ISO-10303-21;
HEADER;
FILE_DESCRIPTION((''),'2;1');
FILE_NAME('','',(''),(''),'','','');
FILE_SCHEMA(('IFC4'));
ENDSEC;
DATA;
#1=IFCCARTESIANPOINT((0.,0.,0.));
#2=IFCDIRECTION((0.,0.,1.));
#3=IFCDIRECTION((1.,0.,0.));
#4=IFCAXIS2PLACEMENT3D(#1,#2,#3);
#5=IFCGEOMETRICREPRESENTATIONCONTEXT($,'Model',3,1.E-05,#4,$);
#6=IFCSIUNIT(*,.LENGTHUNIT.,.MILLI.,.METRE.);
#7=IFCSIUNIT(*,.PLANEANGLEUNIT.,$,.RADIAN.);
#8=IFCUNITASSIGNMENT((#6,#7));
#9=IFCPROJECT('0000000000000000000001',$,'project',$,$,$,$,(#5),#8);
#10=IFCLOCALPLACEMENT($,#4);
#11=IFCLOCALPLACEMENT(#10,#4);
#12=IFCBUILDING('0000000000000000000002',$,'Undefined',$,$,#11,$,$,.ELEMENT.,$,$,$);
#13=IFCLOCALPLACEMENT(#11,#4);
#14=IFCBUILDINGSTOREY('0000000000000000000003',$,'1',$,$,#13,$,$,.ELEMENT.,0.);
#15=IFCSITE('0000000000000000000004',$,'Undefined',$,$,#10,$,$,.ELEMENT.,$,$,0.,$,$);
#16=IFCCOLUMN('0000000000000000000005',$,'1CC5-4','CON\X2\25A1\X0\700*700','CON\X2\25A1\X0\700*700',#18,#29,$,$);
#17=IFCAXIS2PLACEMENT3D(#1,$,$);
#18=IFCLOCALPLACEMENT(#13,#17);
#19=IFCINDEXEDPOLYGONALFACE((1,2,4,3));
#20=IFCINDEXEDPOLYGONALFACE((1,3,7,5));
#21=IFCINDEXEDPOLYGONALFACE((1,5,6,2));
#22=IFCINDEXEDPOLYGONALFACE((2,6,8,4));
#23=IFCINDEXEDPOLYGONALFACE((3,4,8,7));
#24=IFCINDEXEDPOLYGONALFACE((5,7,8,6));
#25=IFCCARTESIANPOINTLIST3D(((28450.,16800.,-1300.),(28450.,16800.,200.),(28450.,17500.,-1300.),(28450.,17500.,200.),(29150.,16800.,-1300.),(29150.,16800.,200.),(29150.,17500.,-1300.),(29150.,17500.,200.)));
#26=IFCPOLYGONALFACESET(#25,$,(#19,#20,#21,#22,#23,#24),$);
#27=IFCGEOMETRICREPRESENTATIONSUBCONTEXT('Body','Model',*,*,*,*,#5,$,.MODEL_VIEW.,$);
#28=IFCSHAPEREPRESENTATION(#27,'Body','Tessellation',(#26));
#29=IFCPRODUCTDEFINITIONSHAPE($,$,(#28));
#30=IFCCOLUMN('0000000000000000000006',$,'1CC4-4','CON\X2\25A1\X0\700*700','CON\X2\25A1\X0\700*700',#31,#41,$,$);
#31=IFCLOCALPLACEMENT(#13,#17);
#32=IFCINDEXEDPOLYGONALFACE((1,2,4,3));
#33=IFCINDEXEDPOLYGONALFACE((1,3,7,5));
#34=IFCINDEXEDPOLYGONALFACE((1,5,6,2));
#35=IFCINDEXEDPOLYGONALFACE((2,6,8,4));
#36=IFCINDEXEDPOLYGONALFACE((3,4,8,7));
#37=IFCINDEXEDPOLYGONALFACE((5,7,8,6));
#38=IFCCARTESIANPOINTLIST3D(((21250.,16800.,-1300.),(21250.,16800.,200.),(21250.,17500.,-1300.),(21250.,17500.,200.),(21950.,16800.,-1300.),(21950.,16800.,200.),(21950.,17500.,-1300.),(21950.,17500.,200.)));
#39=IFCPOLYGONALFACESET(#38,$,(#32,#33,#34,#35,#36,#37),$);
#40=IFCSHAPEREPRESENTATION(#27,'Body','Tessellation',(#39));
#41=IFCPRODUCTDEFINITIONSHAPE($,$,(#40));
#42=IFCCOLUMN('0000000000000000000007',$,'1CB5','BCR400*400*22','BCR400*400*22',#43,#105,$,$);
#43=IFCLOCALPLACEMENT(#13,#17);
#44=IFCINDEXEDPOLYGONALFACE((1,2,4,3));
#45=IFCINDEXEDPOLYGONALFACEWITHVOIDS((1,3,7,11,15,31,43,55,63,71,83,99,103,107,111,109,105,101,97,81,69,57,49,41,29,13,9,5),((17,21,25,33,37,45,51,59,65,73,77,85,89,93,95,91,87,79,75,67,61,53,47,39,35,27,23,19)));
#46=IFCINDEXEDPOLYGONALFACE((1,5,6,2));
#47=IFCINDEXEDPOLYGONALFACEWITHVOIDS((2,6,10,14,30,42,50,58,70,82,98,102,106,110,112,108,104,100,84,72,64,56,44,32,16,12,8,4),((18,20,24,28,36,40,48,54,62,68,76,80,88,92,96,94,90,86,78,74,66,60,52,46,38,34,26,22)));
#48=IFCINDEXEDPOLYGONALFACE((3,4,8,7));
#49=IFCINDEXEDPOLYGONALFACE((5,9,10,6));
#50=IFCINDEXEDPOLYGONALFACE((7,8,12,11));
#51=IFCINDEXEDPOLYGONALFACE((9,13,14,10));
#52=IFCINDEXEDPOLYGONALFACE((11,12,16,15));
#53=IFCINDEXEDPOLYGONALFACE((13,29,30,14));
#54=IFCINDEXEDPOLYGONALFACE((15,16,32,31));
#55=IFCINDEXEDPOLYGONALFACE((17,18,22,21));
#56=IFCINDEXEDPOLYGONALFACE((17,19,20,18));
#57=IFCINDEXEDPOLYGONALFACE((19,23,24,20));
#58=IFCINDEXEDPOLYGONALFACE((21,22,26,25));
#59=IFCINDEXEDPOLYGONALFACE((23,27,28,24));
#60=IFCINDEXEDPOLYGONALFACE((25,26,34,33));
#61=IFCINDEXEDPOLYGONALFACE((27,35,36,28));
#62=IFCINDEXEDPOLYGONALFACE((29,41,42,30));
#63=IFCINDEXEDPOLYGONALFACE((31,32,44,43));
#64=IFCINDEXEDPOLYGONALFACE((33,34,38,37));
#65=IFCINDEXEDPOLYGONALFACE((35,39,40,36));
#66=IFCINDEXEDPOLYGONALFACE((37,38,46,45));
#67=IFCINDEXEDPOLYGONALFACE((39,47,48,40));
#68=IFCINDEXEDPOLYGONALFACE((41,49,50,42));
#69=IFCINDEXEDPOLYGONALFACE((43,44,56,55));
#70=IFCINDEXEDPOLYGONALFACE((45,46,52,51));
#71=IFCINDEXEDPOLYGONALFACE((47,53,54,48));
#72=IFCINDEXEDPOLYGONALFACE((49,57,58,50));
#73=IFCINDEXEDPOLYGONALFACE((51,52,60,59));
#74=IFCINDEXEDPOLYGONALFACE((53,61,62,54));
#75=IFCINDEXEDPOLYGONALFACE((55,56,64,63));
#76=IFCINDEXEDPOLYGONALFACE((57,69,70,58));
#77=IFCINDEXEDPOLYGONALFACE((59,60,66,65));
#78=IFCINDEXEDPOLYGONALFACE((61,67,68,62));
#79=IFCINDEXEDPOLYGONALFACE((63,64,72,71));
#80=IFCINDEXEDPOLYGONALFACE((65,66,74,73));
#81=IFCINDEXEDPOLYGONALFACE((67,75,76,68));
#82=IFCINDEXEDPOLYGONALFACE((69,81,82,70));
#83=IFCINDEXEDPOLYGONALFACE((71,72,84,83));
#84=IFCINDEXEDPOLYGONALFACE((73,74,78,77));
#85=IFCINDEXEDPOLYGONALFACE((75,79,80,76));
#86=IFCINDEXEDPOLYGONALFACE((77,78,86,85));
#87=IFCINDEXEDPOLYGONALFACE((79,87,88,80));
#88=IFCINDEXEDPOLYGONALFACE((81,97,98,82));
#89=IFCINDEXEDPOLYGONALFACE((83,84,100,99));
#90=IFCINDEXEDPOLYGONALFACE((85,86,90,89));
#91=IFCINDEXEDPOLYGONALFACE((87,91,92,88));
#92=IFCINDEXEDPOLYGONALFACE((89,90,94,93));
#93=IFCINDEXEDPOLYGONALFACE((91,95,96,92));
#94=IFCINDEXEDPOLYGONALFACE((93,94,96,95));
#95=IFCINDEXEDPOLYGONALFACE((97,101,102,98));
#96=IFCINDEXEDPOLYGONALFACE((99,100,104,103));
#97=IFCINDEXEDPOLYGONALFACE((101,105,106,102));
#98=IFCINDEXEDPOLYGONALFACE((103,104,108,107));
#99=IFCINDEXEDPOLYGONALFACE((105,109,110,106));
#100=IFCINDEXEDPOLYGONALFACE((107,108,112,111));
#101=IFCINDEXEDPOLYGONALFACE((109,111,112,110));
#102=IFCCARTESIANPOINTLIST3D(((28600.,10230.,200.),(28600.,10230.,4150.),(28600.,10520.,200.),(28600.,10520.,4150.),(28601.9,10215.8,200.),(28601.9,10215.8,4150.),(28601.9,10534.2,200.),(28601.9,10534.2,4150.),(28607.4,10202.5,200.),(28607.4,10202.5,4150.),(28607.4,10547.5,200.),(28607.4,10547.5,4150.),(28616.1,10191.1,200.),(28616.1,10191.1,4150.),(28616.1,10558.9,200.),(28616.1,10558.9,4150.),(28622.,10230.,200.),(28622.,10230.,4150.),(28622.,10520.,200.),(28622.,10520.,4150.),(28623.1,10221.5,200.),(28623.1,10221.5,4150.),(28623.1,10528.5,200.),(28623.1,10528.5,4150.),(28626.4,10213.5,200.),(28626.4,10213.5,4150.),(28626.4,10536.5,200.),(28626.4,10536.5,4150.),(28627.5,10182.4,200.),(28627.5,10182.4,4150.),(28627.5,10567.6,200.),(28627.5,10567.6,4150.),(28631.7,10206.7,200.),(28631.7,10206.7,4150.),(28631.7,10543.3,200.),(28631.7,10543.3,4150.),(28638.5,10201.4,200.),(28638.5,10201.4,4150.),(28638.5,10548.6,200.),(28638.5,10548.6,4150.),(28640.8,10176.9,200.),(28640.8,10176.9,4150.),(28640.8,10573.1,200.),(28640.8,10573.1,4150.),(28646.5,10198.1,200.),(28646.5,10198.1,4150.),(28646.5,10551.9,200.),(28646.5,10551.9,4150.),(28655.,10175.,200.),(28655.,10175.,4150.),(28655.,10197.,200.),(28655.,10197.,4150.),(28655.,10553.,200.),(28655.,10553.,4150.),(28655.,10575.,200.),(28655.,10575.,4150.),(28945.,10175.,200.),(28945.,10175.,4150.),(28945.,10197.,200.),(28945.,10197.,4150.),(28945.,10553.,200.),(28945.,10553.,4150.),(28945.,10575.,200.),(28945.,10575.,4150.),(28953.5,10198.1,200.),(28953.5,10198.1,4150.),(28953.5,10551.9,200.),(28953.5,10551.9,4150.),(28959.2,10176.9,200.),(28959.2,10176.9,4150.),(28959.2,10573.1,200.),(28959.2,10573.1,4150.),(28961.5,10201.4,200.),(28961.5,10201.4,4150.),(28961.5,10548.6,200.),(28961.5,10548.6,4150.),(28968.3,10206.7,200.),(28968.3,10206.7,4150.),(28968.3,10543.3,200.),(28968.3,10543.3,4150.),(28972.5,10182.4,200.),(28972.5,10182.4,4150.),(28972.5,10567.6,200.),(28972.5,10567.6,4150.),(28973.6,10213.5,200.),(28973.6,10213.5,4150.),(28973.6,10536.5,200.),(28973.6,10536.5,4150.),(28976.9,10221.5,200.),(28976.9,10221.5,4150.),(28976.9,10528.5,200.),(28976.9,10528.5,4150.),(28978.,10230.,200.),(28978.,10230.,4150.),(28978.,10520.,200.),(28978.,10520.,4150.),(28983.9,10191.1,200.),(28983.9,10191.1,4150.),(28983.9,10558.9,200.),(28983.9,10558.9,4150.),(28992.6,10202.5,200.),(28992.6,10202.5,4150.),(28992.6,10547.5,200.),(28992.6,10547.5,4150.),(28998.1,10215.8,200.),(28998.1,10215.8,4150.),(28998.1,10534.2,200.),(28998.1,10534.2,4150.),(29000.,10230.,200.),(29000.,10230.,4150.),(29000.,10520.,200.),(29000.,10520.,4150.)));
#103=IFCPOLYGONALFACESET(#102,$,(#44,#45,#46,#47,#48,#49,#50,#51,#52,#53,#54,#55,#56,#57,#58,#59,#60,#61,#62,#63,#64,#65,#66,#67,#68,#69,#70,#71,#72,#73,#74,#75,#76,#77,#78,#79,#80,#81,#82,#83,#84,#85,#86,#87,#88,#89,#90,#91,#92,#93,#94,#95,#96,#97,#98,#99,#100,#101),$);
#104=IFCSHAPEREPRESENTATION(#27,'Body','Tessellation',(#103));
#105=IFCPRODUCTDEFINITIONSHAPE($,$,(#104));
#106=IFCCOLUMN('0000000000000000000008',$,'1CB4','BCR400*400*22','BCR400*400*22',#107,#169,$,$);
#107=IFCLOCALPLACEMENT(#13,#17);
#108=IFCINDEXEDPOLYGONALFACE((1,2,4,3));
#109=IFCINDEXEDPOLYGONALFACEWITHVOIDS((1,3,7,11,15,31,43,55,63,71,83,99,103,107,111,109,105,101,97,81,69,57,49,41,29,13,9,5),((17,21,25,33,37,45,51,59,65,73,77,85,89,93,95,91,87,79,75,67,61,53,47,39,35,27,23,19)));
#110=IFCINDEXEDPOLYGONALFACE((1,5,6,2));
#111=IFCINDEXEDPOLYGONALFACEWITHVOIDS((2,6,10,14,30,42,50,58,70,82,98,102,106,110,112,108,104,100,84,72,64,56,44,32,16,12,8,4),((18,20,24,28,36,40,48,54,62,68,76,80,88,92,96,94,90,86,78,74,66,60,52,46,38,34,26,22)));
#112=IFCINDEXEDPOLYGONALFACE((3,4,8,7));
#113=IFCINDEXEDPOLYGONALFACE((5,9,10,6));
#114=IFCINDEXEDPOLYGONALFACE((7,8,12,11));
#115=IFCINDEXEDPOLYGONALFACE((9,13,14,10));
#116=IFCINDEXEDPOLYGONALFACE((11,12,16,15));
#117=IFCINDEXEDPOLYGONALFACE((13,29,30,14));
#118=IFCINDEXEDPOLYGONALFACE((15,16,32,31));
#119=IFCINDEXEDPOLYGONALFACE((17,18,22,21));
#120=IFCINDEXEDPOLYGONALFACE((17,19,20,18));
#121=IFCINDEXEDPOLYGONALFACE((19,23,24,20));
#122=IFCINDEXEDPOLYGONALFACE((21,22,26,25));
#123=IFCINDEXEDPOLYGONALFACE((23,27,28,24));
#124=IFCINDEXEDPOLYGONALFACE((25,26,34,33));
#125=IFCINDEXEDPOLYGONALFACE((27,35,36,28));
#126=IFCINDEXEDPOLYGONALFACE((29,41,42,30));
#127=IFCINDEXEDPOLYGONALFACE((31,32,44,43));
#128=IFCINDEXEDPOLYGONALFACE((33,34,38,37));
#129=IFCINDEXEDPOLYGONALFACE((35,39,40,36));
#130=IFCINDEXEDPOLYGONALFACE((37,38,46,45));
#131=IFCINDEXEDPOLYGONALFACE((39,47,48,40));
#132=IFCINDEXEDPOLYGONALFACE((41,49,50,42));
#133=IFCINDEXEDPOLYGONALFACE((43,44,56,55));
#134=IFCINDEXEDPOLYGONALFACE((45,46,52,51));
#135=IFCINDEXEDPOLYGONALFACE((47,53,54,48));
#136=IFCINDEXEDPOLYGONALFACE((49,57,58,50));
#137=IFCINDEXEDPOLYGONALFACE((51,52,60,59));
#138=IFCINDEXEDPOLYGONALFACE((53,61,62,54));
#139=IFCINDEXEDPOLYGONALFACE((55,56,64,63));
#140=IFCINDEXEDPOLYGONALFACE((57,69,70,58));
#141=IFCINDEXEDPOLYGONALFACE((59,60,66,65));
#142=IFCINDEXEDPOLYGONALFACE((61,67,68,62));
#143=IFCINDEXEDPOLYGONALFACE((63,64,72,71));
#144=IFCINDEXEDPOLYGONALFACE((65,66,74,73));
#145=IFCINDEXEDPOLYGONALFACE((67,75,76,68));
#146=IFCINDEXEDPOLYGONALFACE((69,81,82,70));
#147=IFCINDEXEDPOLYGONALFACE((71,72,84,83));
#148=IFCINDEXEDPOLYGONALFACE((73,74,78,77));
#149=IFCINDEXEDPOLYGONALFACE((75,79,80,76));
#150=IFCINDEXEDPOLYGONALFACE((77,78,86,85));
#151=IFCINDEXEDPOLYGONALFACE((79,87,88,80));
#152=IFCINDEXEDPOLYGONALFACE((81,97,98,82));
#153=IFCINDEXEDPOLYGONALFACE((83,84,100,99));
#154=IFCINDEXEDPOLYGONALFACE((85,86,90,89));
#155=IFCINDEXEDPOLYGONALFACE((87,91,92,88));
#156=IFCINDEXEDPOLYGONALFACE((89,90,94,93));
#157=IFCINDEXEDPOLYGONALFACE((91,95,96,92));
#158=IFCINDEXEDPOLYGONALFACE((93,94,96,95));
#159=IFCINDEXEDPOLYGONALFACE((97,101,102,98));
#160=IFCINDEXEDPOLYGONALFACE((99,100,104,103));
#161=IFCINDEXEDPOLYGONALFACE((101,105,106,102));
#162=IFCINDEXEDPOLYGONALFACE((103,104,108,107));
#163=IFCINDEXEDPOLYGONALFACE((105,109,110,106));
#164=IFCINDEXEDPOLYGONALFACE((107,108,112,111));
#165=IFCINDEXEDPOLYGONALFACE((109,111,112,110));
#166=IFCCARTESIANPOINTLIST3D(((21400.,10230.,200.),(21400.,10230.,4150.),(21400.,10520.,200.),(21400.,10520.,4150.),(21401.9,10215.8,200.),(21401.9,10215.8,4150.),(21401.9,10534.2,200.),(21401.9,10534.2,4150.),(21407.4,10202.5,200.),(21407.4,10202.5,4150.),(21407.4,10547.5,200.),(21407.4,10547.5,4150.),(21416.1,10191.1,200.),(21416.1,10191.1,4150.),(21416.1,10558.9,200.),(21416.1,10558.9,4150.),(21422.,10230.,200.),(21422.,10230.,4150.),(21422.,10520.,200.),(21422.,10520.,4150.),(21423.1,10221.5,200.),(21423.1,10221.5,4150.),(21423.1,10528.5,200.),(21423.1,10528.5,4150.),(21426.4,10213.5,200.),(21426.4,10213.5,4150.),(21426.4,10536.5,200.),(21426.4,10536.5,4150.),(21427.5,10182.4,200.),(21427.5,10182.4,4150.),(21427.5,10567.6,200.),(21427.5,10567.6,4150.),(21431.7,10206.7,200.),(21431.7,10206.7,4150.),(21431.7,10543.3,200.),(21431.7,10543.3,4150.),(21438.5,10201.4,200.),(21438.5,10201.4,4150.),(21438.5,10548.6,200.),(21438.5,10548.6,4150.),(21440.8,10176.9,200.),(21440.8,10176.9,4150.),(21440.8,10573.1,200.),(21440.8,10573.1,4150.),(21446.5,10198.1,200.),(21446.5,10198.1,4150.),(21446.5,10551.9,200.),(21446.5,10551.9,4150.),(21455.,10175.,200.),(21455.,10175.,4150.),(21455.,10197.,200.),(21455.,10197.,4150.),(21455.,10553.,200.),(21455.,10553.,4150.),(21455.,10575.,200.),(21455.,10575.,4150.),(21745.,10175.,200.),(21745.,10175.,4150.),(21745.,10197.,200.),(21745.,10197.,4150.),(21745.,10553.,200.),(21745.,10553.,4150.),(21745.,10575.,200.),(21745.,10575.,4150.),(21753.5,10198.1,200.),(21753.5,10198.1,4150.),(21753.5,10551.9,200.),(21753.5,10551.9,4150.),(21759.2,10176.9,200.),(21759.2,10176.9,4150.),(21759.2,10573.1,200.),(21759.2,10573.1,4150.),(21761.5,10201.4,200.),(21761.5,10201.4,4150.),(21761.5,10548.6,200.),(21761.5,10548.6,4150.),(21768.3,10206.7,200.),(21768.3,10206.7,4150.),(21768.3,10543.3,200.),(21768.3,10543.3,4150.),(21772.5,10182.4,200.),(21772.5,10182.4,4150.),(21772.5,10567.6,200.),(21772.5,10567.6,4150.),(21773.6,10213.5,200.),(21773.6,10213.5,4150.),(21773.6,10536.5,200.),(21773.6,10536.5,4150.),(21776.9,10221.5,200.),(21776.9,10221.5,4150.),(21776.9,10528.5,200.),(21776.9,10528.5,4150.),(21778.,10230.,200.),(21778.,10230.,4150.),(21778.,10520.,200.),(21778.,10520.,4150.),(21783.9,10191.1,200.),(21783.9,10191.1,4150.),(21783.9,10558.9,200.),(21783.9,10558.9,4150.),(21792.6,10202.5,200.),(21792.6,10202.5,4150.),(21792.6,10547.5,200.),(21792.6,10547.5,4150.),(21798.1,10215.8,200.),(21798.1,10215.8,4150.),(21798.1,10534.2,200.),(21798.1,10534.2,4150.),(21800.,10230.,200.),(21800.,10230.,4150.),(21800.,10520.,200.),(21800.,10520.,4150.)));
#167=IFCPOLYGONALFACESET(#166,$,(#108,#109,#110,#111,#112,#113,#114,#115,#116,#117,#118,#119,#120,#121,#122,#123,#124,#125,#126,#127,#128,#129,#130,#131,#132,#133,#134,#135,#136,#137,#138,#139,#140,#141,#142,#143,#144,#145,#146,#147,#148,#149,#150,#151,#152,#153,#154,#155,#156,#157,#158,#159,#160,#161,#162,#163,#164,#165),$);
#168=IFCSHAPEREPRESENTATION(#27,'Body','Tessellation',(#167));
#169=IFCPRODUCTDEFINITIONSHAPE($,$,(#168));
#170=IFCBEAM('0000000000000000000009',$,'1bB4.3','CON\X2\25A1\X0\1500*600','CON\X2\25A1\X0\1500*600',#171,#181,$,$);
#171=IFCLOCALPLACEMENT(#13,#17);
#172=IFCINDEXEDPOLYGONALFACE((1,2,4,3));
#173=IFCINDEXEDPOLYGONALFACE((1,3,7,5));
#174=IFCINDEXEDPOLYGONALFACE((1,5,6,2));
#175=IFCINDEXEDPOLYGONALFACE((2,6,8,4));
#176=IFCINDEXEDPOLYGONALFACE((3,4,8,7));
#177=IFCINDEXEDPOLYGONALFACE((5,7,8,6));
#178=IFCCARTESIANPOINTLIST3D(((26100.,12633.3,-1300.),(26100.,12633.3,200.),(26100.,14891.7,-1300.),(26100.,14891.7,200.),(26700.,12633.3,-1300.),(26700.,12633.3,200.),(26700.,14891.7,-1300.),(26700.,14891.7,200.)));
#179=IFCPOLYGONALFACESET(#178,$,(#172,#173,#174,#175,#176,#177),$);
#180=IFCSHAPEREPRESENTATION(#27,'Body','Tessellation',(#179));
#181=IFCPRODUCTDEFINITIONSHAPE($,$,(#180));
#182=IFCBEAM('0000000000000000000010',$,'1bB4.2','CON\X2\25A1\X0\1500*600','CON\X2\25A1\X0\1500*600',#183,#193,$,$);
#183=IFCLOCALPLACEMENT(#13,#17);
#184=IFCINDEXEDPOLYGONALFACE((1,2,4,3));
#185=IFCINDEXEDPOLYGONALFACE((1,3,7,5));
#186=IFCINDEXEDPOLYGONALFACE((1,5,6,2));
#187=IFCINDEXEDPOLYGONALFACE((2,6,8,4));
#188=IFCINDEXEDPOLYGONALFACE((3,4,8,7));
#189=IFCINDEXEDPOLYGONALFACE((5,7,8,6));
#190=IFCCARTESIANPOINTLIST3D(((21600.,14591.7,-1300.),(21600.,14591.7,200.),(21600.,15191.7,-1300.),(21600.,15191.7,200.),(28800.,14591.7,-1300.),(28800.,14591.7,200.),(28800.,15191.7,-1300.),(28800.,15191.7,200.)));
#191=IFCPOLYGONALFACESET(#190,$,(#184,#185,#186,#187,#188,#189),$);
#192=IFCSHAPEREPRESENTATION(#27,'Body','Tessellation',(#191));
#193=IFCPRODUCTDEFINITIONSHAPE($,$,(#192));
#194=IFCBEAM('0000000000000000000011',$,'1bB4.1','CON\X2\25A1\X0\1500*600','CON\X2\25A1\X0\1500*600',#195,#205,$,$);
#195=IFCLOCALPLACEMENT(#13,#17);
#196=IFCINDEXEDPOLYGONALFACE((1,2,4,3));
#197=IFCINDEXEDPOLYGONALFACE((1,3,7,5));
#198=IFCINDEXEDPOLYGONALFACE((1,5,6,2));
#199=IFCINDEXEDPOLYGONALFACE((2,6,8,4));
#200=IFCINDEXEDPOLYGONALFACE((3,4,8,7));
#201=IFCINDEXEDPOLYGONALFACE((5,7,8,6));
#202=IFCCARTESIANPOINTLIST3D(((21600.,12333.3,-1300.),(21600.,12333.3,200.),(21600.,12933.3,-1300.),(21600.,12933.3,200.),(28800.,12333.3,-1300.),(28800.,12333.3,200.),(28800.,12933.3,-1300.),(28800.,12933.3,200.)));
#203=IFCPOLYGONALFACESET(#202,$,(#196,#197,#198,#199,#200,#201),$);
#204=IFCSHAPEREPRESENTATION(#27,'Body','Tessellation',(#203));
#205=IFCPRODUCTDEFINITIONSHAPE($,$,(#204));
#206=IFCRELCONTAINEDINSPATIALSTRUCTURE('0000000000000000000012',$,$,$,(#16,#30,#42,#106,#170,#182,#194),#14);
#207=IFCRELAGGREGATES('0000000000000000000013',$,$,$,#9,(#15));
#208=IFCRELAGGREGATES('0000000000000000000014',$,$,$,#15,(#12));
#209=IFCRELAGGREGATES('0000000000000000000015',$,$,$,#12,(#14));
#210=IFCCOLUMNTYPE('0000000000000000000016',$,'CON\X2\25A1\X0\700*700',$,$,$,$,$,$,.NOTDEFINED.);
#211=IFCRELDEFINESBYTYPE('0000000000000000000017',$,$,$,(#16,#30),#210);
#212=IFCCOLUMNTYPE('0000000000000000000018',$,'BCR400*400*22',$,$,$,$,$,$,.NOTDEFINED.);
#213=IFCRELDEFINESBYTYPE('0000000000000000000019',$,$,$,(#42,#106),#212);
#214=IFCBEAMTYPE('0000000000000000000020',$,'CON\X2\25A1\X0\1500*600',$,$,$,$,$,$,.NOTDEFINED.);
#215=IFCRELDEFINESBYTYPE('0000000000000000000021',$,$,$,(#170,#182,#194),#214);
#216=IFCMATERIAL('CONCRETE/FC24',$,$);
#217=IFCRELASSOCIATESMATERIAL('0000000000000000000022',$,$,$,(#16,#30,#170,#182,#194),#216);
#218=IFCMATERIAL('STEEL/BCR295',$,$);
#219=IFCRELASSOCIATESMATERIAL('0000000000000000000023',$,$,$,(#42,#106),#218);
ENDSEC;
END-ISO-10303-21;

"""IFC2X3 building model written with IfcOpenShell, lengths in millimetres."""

from ifc_helpers import new_model, si_unit, frame, origin_with_axes, origin_2d_with_axis, place, context, subcontext, project, spatial, rectangle, hollow_rectangle, extrude, material, type_object, element, save


model = new_model("IFC2X3")

# Units and contexts
model_context = context("Model", 3, precision=1e-05, world=origin_with_axes())
body_context = subcontext(model_context, "Body", "Model", "MODEL_VIEW")
ifc_project = project(units=[si_unit("LENGTHUNIT", "METRE", prefix="MILLI"), si_unit("PLANEANGLEUNIT", "RADIAN")], contexts=[model_context])

# Site, building, storey
site_placement = place(None, origin_with_axes())
site = spatial("IfcSite", under=ifc_project, at=site_placement, Name="Undefined", CompositionType="ELEMENT", RefElevation=0.0)
building_placement = place(site_placement, origin_with_axes())
building = spatial("IfcBuilding", under=site, at=building_placement, Name="Undefined", CompositionType="ELEMENT")
storey_placement = place(building_placement, origin_with_axes())
storey = spatial("IfcBuildingStorey", under=building, at=storey_placement, Name="1", CompositionType="ELEMENT", Elevation=0.0)

# Shared definitions
ifc_material_1 = material(Name="CONCRETE/FC24")

# Columns
ifc_material_2 = material(Name="STEEL/BCR295")
column_type_1 = type_object("IfcColumnType", Name="CON□700*700", PredefinedType="NOTDEFINED")
for number, where, z_axis, x_axis, name in (
    (1, (28800.0, 17150.0, -1300.0), (0.0, 0.0, 1.0), (0.0, 1.0, 0.0), "1CC5-4"),
    (2, (21600.0, 17150.0, -1300.0), (0.0, 0.0, 1.0), (0.0, 1.0, 0.0), "1CC4-4"),
):
    element("IfcColumn", number, at=place(storey_placement, frame(where, z_axis=z_axis, x_axis=x_axis)), inside=storey, type_object=column_type_1, material=ifc_material_1, Name=name, Description="CON□700*700", ObjectType="CON□700*700", context=body_context, shape_type="SweptSolid", body=[
        extrude(rectangle(XDim=700.0, YDim=700.0, at=origin_2d_with_axis()), frame((0.0, 0.0, 1500.0), z_axis=(0.0, 0.0, -1.0), x_axis=(0.0, 1.0, 0.0)), (0.0, 0.0, 1.0), 1500.0),
    ])
column_type_2 = type_object("IfcColumnType", Name="BCR400*400*22", PredefinedType="NOTDEFINED")
for number, where, z_axis, x_axis, name in (
    (3, (28800.0, 10375.0, 200.0), (0.0, 0.0, 1.0), (0.0, 1.0, 0.0), "1CB5"),
    (4, (21600.0, 10375.0, 200.0), (0.0, 0.0, 1.0), (0.0, 1.0, 0.0), "1CB4"),
):
    element("IfcColumn", number, at=place(storey_placement, frame(where, z_axis=z_axis, x_axis=x_axis)), inside=storey, type_object=column_type_2, material=ifc_material_2, Name=name, Description="BCR400*400*22", ObjectType="BCR400*400*22", context=body_context, shape_type="SweptSolid", body=[
        extrude(hollow_rectangle(XDim=400.0, YDim=400.0, WallThickness=22.0, InnerFilletRadius=33.0, OuterFilletRadius=55.0, at=origin_2d_with_axis()), frame((0.0, 0.0, 3950.0), z_axis=(0.0, 0.0, -1.0), x_axis=(0.0, 1.0, 0.0)), (0.0, 0.0, 1.0), 3950.0),
    ])

# Beams
beam_type = type_object("IfcBeamType", Name="CON□1500*600", PredefinedType="NOTDEFINED")
beam_1_placement = place(storey_placement, frame((26400.0, 12633.3, -550.0), z_axis=(0.0, 0.0, 1.0), x_axis=(0.0, 1.0, 0.0)))
element("IfcBeam", 5, at=beam_1_placement, inside=storey, type_object=beam_type, material=ifc_material_1, Name="1bB4.3", Description="CON□1500*600", ObjectType="CON□1500*600", context=body_context, shape_type="SweptSolid", body=[
    extrude(rectangle(XDim=600.0, YDim=1500.0, at=origin_2d_with_axis()), frame((2258.4, 0.0, 0.0), z_axis=(-1.0, 0.0, 0.0), x_axis=(0.0, -1.0, 0.0)), (0.0, 0.0, 1.0), 2258.4),
])
for number, where, z_axis, x_axis, name in (
    (6, (21600.0, 14891.7, -550.0), (0.0, 0.0, 1.0), (1.0, 0.0, 0.0), "1bB4.2"),
    (7, (21600.0, 12633.3, -550.0), (0.0, 0.0, 1.0), (1.0, 0.0, 0.0), "1bB4.1"),
):
    element("IfcBeam", number, at=place(storey_placement, frame(where, z_axis=z_axis, x_axis=x_axis)), inside=storey, type_object=beam_type, material=ifc_material_1, Name=name, Description="CON□1500*600", ObjectType="CON□1500*600", context=body_context, shape_type="SweptSolid", body=[
        extrude(rectangle(XDim=600.0, YDim=1500.0, at=origin_2d_with_axis()), frame((7200.0, 0.0, 0.0), z_axis=(-1.0, 0.0, 0.0), x_axis=(0.0, -1.0, 0.0)), (0.0, 0.0, 1.0), 7200.0),
    ])

save(model, "model.ifc")
